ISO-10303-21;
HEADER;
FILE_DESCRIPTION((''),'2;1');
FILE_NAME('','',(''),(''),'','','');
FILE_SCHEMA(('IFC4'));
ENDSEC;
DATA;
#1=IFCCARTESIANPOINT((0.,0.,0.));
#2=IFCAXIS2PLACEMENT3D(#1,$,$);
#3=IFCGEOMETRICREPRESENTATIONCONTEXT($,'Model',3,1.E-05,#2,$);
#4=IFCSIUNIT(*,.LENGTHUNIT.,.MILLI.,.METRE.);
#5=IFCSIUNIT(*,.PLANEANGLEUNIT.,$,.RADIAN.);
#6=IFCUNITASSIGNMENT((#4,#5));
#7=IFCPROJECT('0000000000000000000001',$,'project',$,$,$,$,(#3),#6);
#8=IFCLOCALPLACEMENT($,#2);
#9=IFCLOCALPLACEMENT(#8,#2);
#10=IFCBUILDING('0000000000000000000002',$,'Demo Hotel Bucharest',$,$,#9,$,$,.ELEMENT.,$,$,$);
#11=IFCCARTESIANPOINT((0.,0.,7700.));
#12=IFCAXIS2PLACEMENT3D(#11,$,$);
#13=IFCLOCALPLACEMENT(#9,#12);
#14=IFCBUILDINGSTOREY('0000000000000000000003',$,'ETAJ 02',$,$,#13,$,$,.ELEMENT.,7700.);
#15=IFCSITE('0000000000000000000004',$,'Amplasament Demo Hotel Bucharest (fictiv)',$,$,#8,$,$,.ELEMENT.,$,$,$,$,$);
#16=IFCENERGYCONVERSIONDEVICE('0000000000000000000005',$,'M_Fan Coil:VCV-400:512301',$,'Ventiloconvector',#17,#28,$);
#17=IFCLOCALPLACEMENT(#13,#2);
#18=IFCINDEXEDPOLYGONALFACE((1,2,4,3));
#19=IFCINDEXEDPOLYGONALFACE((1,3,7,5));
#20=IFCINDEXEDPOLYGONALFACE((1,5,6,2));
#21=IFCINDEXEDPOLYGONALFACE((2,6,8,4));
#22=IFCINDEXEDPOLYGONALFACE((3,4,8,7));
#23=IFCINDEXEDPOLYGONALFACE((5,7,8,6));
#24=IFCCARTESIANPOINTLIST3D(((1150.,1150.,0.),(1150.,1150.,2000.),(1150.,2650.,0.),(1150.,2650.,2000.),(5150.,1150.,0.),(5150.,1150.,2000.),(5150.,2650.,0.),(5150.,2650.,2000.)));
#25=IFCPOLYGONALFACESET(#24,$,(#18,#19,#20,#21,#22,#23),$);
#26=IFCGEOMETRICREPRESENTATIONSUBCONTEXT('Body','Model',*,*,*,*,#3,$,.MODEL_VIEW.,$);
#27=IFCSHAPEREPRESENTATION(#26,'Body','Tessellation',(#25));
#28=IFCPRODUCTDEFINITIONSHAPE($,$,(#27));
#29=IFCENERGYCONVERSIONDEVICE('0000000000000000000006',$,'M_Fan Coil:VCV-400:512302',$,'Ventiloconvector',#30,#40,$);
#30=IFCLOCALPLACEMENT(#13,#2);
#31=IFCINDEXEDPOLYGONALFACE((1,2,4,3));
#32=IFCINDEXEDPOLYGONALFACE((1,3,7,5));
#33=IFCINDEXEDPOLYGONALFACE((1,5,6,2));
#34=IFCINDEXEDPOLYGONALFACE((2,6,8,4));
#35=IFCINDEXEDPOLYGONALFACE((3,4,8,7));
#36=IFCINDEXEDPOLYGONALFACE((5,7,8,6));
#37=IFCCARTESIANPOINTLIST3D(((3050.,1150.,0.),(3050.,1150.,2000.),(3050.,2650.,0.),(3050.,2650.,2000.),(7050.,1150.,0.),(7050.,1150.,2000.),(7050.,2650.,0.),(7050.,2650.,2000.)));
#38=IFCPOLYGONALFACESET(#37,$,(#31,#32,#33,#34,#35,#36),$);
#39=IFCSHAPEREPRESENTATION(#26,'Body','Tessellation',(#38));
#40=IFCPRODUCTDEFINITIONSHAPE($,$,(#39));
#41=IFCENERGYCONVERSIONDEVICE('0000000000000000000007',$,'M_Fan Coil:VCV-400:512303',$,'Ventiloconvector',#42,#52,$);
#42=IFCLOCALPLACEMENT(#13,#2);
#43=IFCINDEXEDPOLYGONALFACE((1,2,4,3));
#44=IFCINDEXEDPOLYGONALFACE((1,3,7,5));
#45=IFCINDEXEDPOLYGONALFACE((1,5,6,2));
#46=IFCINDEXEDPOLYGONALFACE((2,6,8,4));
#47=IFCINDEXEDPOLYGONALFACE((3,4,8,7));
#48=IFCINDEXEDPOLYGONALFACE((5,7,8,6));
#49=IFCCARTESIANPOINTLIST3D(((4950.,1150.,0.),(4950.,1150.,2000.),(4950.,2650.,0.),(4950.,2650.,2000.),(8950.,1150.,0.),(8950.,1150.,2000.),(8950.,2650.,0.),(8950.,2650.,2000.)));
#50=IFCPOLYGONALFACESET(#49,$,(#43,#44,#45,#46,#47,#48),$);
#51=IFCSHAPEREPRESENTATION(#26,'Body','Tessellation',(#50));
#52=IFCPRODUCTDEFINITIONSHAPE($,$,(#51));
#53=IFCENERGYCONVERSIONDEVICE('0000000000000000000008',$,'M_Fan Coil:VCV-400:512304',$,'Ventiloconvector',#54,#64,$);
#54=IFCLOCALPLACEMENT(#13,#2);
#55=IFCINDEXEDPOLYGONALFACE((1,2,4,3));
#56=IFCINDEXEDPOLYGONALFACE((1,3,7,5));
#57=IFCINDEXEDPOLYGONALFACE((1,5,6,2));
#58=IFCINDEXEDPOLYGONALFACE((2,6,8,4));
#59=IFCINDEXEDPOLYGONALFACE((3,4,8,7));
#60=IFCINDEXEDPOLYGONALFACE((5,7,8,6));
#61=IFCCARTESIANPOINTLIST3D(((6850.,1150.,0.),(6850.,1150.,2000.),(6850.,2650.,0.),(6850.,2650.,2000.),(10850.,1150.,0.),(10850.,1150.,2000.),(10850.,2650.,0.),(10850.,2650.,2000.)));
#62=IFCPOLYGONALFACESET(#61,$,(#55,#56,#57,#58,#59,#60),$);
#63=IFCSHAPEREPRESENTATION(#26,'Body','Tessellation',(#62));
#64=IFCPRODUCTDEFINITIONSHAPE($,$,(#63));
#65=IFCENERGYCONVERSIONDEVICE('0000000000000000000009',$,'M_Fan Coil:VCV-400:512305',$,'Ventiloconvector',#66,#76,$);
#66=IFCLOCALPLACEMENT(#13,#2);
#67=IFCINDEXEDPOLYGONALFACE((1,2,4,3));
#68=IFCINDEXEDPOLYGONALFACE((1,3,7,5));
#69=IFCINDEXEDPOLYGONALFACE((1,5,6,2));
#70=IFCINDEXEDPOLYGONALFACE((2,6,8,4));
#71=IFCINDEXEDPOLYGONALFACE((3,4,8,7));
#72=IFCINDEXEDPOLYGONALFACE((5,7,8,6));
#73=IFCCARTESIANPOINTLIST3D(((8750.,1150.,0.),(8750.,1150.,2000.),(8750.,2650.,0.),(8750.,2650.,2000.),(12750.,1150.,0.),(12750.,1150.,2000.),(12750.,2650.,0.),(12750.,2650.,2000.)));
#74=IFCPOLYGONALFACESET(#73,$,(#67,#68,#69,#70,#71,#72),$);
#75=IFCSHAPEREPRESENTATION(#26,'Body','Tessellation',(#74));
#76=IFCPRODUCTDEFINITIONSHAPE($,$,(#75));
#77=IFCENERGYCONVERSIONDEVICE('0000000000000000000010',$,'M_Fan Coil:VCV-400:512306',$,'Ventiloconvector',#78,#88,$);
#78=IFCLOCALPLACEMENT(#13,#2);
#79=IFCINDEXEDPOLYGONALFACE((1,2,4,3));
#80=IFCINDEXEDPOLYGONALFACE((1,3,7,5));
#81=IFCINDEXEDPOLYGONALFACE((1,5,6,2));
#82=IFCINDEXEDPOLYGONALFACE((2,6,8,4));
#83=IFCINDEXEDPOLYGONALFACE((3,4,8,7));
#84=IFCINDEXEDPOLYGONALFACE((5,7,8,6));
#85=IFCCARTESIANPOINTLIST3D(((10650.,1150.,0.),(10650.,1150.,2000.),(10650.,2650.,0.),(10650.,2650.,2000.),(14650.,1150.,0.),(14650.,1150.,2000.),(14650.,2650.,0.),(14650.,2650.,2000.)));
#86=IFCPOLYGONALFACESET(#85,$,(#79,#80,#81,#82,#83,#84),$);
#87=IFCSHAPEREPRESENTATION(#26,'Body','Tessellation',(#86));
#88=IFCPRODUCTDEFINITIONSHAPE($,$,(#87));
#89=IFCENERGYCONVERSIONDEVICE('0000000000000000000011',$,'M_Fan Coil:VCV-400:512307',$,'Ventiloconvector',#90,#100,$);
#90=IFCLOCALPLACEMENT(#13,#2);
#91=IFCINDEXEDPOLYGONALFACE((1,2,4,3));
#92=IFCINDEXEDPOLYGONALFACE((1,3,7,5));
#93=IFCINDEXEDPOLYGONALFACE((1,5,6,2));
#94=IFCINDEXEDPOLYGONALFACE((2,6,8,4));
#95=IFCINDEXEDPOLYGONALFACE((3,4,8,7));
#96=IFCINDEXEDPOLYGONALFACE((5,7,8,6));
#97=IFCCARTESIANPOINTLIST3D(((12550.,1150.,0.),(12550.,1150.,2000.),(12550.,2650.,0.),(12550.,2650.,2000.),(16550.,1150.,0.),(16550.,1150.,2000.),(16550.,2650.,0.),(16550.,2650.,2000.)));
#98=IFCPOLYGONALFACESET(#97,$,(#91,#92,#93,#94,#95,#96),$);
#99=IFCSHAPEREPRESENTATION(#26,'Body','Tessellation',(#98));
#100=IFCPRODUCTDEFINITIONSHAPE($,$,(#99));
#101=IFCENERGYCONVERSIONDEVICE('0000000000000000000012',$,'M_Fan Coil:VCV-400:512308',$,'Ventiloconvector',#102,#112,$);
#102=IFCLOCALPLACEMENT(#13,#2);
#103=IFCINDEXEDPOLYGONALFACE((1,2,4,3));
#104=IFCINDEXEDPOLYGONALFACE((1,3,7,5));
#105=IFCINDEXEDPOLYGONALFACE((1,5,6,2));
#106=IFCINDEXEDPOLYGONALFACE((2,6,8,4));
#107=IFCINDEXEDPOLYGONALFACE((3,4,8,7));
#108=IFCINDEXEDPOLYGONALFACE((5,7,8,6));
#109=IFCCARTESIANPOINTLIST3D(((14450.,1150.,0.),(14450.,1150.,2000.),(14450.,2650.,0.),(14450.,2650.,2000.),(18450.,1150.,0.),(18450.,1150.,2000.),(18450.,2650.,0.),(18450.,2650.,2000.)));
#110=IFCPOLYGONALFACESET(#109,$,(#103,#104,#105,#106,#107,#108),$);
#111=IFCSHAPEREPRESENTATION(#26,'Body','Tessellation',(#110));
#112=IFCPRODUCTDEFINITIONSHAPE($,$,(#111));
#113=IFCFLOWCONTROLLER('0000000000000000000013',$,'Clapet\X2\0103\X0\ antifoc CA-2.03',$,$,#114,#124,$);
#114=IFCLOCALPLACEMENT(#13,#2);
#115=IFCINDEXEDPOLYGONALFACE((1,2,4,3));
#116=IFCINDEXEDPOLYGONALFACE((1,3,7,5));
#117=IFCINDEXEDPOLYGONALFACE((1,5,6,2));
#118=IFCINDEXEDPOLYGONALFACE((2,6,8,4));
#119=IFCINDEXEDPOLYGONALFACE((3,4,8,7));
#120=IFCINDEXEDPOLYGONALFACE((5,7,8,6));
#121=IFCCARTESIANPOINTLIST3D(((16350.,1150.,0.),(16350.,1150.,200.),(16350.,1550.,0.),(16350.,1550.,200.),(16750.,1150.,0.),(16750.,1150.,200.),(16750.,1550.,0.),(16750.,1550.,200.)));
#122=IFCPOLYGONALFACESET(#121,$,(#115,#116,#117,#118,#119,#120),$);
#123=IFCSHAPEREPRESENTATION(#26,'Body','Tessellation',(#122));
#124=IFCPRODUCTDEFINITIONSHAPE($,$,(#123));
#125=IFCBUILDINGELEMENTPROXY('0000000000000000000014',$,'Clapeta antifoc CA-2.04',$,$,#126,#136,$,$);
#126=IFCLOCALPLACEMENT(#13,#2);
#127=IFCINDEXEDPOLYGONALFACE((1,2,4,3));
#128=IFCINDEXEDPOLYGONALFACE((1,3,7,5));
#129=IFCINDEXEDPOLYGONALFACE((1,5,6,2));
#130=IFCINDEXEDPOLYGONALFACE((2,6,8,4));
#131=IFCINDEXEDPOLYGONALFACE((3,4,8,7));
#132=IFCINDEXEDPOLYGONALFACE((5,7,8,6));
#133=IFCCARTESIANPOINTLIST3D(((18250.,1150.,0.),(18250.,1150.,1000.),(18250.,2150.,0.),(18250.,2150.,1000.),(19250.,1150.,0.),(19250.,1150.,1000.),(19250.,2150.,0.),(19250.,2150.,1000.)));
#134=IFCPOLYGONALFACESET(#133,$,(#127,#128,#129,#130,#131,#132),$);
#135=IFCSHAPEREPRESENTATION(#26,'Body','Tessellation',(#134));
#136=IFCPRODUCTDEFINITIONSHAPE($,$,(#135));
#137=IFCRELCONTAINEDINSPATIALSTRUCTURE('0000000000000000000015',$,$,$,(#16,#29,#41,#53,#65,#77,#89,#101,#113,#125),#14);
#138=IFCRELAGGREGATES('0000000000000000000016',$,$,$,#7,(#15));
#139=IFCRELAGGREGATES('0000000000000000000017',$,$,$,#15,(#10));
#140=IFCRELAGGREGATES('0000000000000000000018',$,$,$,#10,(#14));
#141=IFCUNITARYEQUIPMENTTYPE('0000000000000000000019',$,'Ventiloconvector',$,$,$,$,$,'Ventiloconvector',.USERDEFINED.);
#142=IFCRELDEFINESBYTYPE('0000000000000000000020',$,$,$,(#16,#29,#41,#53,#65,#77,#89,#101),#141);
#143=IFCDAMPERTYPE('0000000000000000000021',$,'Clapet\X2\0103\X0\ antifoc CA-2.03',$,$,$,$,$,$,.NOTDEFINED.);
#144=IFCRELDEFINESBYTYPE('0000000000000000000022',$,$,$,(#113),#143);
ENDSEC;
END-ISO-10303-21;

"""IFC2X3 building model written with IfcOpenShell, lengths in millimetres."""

from ifc_helpers import new_model, si_unit, frame, frame_2d, origin, place, context, subcontext, project, spatial, rectangle, extrude, type_object, element, save


model = new_model("IFC2X3")

# Units and contexts
model_context = context("Model", 3, precision=1e-05, world=origin())
body_context = subcontext(model_context, "Body", "Model", "MODEL_VIEW")
ifc_project = project(units=[si_unit("LENGTHUNIT", "METRE", prefix="MILLI"), si_unit("PLANEANGLEUNIT", "RADIAN")], contexts=[model_context])

# Site, building, storey
site_placement = place(None, origin())
site = spatial("IfcSite", under=ifc_project, at=site_placement, Name="Amplasament Demo Hotel Bucharest (fictiv)", CompositionType="ELEMENT")
building_placement = place(site_placement, origin())
building = spatial("IfcBuilding", under=site, at=building_placement, Name="Demo Hotel Bucharest", CompositionType="ELEMENT")
storey_placement = place(building_placement, frame((0.0, 0.0, 7700.0)))
storey = spatial("IfcBuildingStorey", under=building, at=storey_placement, Name="ETAJ 02", CompositionType="ELEMENT", Elevation=7700.0)

# Energy conversion devices
unitary_equipment_type = type_object("IfcUnitaryEquipmentType", Name="Ventiloconvector", ElementType="Ventiloconvector", PredefinedType="USERDEFINED")
for number, where, name in (
    (1, (1150.0, 1150.0, 0.0), "M_Fan Coil:VCV-400:512301"),
    (2, (3050.0, 1150.0, 0.0), "M_Fan Coil:VCV-400:512302"),
    (3, (4950.0, 1150.0, 0.0), "M_Fan Coil:VCV-400:512303"),
    (4, (6850.0, 1150.0, 0.0), "M_Fan Coil:VCV-400:512304"),
    (5, (8750.0, 1150.0, 0.0), "M_Fan Coil:VCV-400:512305"),
    (6, (10650.0, 1150.0, 0.0), "M_Fan Coil:VCV-400:512306"),
    (7, (12550.0, 1150.0, 0.0), "M_Fan Coil:VCV-400:512307"),
    (8, (14450.0, 1150.0, 0.0), "M_Fan Coil:VCV-400:512308"),
):
    element("IfcEnergyConversionDevice", number, at=place(storey_placement, frame(where)), inside=storey, type_object=unitary_equipment_type, Name=name, ObjectType="Ventiloconvector", context=body_context, shape_type="SweptSolid", body=[
        extrude(rectangle(XDim=4000.0, YDim=1500.0, at=frame_2d((2000.0, 750.0))), origin(), (0.0, 0.0, 1.0), 2000.0),
    ])

# Flow controller
damper_type = type_object("IfcDamperType", Name="Clapetă antifoc CA-2.03", PredefinedType="NOTDEFINED")
flow_controller_placement = place(storey_placement, frame((16350.0, 1150.0, 0.0)))
element("IfcFlowController", 9, at=flow_controller_placement, inside=storey, type_object=damper_type, Name="Clapetă antifoc CA-2.03", context=body_context, shape_type="SweptSolid", body=[
    extrude(rectangle(XDim=400.0, YDim=400.0, at=frame_2d((200.0, 200.0))), origin(), (0.0, 0.0, 1.0), 200.0),
])

# Building element proxy
proxy_placement = place(storey_placement, frame((18250.0, 1150.0, 0.0)))
element("IfcBuildingElementProxy", 10, at=proxy_placement, inside=storey, Name="Clapeta antifoc CA-2.04", context=body_context, shape_type="SweptSolid", body=[
    extrude(rectangle(XDim=1000.0, YDim=1000.0, at=frame_2d((500.0, 500.0))), origin(), (0.0, 0.0, 1.0), 1000.0),
])

save(model, "model.ifc")
